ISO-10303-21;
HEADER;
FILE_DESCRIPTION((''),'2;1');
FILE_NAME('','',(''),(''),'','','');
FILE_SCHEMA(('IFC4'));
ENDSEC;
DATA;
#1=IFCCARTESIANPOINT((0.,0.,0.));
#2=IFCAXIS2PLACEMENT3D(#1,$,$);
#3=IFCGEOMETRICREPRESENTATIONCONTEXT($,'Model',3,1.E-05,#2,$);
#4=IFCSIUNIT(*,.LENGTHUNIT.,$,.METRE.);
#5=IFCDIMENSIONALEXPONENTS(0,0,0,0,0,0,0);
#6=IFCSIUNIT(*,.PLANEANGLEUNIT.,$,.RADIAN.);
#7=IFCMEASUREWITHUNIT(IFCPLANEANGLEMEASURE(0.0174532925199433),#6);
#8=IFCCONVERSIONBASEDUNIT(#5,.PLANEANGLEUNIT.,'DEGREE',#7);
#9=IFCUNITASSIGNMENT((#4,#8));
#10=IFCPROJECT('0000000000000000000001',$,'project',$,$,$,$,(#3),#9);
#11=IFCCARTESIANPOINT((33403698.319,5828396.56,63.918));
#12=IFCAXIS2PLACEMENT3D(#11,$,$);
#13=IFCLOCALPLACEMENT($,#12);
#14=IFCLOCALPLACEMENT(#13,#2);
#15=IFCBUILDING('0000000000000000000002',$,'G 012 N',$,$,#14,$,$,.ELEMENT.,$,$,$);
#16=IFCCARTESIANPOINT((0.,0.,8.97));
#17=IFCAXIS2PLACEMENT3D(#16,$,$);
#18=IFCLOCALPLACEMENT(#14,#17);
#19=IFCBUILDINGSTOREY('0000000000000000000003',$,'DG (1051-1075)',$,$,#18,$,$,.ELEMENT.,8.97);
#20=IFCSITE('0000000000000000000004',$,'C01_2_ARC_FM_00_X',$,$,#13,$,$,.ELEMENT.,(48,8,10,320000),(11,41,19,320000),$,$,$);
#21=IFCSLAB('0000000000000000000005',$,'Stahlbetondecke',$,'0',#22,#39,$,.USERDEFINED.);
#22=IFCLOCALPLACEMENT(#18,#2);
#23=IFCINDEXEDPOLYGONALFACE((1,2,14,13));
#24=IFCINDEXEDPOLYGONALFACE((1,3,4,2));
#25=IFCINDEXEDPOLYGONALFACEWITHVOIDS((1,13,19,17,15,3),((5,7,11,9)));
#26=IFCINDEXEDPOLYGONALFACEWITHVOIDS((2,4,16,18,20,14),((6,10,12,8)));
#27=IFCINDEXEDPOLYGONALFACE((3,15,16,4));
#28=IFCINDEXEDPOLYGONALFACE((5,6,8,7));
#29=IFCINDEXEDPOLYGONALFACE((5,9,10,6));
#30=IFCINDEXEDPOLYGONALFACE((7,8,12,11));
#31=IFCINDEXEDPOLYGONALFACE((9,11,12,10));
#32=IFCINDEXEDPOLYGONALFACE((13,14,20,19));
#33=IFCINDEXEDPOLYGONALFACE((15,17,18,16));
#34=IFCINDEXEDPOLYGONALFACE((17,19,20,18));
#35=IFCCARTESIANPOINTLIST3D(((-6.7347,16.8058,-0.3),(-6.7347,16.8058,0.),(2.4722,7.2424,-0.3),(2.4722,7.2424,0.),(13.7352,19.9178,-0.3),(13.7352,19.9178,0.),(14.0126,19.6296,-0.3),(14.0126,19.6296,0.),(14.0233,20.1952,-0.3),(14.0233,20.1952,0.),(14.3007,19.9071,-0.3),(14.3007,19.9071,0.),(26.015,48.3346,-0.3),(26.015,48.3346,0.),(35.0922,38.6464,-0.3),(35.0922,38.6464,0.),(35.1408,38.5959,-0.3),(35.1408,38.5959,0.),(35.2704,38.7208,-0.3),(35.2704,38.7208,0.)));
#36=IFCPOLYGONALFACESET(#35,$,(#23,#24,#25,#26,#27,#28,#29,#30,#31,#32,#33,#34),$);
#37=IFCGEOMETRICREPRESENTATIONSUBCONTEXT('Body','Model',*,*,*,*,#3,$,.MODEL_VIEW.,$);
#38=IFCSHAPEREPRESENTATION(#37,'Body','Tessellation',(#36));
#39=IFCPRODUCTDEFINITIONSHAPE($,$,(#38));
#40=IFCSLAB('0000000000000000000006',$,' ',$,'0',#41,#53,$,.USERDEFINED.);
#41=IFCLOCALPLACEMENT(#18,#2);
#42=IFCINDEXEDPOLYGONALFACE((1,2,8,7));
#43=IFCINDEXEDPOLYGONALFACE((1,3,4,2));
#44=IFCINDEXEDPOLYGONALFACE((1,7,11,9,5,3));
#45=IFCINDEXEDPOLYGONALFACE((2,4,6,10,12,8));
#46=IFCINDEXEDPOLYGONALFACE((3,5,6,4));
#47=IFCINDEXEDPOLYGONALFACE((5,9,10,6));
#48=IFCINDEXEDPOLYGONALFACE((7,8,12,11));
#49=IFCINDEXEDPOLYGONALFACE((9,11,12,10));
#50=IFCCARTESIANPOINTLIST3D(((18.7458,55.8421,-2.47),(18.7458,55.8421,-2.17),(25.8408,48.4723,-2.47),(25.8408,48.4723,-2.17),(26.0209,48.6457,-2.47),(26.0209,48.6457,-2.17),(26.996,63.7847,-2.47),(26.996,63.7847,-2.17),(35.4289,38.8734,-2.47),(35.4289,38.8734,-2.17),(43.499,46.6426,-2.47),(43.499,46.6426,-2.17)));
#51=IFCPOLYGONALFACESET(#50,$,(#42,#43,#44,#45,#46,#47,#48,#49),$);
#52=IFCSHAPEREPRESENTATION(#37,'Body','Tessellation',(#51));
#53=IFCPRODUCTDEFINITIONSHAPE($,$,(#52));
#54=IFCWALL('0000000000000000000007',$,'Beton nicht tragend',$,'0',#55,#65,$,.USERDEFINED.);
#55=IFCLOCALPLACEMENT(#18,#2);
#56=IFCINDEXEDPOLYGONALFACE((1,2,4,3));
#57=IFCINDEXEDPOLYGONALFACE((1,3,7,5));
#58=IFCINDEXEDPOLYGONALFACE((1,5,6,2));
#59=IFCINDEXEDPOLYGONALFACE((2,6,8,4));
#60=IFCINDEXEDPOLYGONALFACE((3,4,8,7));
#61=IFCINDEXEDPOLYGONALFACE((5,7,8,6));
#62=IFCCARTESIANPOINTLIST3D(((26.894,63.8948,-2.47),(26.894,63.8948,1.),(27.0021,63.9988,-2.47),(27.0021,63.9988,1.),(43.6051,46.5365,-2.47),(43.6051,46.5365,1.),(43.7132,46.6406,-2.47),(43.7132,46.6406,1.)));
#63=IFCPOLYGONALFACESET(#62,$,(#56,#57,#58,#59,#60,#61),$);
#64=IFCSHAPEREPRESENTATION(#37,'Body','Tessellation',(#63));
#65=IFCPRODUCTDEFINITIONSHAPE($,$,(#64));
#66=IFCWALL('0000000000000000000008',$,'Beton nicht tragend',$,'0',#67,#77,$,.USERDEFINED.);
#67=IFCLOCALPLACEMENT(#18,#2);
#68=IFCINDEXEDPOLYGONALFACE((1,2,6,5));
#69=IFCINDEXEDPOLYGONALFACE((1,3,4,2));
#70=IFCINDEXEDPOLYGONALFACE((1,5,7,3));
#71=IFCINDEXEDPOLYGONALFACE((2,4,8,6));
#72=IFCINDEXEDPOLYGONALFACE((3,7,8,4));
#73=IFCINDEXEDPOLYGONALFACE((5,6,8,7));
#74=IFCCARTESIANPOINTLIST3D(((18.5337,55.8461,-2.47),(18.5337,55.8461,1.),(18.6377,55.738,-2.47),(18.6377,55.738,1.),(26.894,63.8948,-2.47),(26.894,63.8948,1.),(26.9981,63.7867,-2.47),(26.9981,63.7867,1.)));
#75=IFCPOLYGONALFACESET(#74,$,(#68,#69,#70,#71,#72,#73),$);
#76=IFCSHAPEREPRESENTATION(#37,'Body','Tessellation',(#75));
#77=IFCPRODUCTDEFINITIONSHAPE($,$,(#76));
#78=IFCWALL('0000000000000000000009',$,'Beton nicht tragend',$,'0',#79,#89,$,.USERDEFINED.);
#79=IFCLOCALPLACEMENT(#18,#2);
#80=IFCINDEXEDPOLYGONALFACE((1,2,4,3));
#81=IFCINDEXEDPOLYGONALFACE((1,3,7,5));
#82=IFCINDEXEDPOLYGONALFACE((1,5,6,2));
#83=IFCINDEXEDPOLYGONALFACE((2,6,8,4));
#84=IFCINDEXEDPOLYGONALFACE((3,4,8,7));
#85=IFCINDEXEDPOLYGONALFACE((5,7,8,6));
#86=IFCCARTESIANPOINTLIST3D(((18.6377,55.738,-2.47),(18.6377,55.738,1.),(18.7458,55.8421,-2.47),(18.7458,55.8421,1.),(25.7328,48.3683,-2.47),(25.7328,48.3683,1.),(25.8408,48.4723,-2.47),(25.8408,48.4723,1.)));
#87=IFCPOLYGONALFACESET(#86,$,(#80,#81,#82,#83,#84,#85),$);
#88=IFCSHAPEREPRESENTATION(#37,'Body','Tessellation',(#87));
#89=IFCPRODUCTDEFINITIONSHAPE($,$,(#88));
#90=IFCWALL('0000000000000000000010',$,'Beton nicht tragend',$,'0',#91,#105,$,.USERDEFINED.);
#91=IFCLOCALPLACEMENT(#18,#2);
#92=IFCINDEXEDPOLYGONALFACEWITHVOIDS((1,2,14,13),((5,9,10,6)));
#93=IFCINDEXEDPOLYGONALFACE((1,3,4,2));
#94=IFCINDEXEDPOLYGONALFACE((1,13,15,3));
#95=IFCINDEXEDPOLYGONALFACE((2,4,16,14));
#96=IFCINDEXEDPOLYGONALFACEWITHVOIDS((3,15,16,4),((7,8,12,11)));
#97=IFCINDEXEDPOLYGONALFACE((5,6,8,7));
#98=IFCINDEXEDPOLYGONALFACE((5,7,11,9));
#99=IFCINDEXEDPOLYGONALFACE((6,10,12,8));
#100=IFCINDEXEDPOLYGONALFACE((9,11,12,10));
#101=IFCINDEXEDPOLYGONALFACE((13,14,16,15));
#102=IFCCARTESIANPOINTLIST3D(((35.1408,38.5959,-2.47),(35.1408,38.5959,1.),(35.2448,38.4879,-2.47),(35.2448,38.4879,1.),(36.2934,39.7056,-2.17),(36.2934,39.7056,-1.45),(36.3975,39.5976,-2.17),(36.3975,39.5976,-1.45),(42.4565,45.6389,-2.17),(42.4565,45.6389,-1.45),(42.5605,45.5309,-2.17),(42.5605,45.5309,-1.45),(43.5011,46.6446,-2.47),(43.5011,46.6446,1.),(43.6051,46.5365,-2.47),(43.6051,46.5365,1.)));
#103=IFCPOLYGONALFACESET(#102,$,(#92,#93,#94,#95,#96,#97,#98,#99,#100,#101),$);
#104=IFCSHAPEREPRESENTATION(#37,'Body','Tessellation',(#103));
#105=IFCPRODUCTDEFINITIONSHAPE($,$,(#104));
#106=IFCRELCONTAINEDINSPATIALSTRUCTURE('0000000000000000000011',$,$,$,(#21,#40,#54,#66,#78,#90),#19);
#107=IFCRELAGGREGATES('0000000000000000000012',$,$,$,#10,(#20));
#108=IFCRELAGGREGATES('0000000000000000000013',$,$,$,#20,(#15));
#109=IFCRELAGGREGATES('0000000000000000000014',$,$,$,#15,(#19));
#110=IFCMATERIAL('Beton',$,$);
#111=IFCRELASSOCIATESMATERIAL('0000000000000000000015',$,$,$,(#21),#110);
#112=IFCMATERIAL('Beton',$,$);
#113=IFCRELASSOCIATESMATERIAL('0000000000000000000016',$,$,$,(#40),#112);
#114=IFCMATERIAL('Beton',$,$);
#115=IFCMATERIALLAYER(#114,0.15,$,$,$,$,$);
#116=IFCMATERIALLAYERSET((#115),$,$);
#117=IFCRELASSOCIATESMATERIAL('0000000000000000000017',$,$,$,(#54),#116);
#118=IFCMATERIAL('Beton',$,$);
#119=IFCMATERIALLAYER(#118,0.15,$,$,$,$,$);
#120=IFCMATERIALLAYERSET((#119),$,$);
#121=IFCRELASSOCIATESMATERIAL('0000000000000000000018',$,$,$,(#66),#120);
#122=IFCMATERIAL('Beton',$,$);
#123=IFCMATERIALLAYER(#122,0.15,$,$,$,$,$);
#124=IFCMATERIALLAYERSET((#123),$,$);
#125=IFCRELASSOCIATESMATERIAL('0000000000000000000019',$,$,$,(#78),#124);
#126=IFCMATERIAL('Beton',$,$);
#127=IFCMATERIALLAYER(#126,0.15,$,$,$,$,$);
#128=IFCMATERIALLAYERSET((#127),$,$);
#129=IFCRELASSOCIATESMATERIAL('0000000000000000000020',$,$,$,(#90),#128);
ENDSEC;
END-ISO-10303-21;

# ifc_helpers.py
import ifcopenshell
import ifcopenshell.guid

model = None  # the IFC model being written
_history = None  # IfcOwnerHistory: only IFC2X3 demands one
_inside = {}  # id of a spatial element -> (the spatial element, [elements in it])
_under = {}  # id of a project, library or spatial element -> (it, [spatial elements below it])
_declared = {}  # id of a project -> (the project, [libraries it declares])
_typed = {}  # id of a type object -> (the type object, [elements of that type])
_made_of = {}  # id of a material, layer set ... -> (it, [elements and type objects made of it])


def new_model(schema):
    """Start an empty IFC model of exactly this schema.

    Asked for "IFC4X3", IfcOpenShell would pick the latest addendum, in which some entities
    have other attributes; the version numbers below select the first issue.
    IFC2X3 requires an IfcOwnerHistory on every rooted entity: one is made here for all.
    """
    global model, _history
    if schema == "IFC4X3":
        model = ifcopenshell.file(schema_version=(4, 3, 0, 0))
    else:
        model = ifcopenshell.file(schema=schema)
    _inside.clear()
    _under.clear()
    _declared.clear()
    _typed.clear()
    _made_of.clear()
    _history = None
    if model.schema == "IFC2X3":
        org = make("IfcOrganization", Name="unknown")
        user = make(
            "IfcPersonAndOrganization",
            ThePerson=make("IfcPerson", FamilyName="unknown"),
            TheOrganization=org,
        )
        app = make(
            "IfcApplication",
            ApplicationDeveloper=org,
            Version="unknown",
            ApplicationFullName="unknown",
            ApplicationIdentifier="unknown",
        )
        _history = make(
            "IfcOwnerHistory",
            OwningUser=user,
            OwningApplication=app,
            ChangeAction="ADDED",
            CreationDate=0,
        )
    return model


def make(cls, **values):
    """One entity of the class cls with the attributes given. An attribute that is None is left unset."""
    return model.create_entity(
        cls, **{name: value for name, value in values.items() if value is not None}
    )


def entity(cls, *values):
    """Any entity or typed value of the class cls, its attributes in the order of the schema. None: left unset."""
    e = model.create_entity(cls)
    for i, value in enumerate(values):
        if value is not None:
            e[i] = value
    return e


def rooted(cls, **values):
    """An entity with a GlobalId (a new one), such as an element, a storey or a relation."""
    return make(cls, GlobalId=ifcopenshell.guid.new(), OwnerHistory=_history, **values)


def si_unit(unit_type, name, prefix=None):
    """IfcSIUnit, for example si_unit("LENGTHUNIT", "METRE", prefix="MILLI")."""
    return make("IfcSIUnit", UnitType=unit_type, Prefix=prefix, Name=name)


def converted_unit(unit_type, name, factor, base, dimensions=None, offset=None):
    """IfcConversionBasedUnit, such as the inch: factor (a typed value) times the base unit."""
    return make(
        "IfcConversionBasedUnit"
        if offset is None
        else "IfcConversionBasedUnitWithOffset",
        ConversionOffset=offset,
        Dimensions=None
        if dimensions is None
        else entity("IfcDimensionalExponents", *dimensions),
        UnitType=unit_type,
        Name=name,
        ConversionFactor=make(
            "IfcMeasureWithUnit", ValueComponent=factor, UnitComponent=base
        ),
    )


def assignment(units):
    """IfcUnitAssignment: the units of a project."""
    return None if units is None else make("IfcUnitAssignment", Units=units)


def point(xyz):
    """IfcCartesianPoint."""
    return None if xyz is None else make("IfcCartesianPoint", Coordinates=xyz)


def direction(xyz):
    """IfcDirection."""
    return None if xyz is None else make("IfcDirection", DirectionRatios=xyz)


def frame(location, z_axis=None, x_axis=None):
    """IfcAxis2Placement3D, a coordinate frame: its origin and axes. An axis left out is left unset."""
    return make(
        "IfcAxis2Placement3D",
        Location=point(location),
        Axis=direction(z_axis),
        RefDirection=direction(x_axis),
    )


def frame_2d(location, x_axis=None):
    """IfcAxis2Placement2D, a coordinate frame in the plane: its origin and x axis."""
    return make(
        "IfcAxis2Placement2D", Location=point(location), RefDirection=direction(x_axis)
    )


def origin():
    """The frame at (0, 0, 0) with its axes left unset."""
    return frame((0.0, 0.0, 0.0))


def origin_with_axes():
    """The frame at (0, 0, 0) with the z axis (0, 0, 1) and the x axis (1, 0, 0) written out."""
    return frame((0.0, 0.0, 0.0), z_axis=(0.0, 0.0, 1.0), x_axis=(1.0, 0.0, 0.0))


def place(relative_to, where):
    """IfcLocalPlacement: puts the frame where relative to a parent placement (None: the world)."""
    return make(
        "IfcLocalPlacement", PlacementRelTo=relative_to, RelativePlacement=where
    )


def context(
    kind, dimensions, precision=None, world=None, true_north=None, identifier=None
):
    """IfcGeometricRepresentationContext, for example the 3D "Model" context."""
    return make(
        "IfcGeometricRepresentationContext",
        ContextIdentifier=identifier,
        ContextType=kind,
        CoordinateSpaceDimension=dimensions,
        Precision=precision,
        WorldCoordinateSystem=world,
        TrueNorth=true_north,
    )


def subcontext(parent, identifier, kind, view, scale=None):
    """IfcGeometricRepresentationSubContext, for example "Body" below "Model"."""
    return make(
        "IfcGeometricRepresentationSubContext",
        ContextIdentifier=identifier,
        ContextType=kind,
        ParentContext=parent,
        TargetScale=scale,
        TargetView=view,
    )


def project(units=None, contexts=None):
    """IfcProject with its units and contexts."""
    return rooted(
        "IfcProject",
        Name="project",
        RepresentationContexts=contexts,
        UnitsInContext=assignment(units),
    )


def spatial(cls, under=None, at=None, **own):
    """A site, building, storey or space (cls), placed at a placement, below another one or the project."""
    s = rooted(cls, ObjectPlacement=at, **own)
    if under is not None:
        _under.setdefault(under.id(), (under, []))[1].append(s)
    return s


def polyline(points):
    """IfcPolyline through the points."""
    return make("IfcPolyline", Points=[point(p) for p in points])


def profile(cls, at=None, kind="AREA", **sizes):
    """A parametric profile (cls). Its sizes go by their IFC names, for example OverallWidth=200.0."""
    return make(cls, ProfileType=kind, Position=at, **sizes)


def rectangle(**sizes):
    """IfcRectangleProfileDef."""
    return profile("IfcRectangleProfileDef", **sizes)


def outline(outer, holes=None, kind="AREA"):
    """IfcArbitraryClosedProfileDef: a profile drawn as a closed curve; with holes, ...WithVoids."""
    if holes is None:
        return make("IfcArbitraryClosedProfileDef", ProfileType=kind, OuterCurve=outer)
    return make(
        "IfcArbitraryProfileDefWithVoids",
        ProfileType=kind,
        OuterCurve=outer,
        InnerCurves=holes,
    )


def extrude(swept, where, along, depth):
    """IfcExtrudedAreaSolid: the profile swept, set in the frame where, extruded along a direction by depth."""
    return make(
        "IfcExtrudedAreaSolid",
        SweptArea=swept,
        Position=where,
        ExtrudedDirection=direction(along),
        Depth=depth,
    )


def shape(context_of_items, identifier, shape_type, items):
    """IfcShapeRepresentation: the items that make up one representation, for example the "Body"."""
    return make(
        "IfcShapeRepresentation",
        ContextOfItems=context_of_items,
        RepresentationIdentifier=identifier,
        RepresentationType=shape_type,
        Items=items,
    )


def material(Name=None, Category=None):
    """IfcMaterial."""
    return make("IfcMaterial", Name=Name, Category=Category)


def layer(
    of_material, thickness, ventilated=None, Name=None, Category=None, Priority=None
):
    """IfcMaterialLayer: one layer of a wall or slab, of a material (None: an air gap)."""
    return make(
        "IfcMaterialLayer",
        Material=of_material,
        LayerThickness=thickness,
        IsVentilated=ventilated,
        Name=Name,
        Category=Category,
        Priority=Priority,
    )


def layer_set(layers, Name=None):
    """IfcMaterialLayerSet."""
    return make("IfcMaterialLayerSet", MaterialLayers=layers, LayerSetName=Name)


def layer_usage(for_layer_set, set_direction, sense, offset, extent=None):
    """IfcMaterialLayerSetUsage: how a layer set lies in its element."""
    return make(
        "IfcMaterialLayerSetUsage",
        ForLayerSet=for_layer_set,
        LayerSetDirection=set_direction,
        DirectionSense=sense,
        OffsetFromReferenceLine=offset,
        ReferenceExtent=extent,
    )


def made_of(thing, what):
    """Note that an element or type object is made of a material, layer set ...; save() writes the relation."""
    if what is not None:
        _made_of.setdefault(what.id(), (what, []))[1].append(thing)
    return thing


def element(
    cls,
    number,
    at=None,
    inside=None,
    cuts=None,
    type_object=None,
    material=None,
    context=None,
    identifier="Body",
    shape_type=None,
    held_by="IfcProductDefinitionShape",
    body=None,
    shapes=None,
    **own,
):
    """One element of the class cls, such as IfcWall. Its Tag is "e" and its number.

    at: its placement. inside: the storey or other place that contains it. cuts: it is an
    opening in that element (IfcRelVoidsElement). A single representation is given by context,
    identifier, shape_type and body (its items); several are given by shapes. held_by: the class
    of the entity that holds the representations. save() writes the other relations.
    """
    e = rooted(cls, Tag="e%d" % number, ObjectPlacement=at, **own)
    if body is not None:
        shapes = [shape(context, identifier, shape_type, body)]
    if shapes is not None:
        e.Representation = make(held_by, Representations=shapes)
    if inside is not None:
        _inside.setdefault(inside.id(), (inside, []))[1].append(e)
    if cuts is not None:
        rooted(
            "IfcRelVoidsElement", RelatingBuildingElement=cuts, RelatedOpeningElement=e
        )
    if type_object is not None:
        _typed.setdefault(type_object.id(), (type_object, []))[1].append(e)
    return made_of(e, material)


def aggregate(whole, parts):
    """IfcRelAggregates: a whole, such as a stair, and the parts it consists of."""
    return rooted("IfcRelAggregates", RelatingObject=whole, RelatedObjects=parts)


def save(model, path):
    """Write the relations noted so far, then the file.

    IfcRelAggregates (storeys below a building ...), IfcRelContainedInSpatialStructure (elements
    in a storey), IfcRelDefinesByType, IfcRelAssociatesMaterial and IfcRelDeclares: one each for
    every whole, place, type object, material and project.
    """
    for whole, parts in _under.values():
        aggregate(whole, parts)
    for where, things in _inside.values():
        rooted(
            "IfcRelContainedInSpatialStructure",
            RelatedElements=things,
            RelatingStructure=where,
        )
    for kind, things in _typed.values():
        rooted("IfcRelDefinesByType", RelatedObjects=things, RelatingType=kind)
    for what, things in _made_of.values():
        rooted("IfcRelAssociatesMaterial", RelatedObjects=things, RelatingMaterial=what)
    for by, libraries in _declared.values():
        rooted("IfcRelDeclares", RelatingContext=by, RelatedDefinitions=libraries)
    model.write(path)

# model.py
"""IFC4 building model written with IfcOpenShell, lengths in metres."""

from ifc_helpers import new_model, entity, si_unit, converted_unit, frame, frame_2d, origin, origin_with_axes, place, context, subcontext, project, spatial, polyline, rectangle, outline, extrude, material, layer, layer_set, layer_usage, element, save


model = new_model("IFC4")

# Units and contexts
model_context = context("Model", 3, precision=1e-05, world=origin())
body_context = subcontext(model_context, "Body", "Model", "MODEL_VIEW")
ifc_project = project(units=[si_unit("LENGTHUNIT", "METRE"), converted_unit("PLANEANGLEUNIT", "DEGREE", entity("IfcPlaneAngleMeasure", 0.0174532925199433), si_unit("PLANEANGLEUNIT", "RADIAN"), dimensions=[0, 0, 0, 0, 0, 0, 0])], contexts=[model_context])

# Site, building, storey
site_placement = place(None, frame((33403698.319, 5828396.56, 63.918)))
site = spatial("IfcSite", under=ifc_project, at=site_placement, Name="C01_2_ARC_FM_00_X", CompositionType="ELEMENT", RefLatitude=(48, 8, 10, 320000), RefLongitude=(11, 41, 19, 320000))
building_placement = place(site_placement, origin())
building = spatial("IfcBuilding", under=site, at=building_placement, Name="G 012 N", CompositionType="ELEMENT")
storey_placement = place(building_placement, frame((0.0, 0.0, 8.97)))
storey = spatial("IfcBuildingStorey", under=building, at=storey_placement, Name="DG (1051-1075)", CompositionType="ELEMENT", Elevation=8.97)

# Slab, opening
ifc_material_1 = material(Name="Beton")
slab_1_placement = place(storey_placement, frame((-6.7347, 7.2424, -0.3)))
slab_1 = element("IfcSlab", 1, at=slab_1_placement, inside=storey, material=ifc_material_1, Name="Stahlbetondecke", ObjectType="0", PredefinedType="USERDEFINED", context=body_context, shape_type="SweptSolid", body=[
    extrude(outline(polyline([(41.8755, 31.3535), (42.0052, 31.4784), (32.7497, 41.0922), (0.0, 9.5634), (9.2069, 0.0), (41.827, 31.404), (41.8755, 31.3535)])), origin_with_axes(), (0.0, 0.0, 1.0), 0.3),
])
opening_1_placement = place(slab_1_placement, frame((20.4699, 12.3873, 0.0)))
element("IfcOpeningElement", 2, at=opening_1_placement, cuts=slab_1, ObjectType="Opening", context=body_context, shape_type="SweptSolid", body=[
    extrude(rectangle(XDim=0.4, YDim=0.4, at=frame_2d((0.0, 0.0), x_axis=(-0.693551, 0.720408))), frame((0.2828, 0.2828, 0.0), z_axis=(0.0, 0.0, 1.0), x_axis=(1.0, 0.0, 0.0)), (0.0, 0.0, 1.0), 0.3),
])

# Slab
ifc_material_2 = material(Name="Beton")
slab_2_placement = place(storey_placement, frame((18.7458, 38.8734, -2.47)))
element("IfcSlab", 3, at=slab_2_placement, inside=storey, material=ifc_material_2, Name=" ", ObjectType="0", PredefinedType="USERDEFINED", context=body_context, shape_type="SweptSolid", body=[
    extrude(outline(polyline([(8.2502, 24.9114), (0.0, 16.9687), (7.095, 9.5989), (7.2751, 9.7723), (16.6831, 0.0), (24.7532, 7.7692), (8.2502, 24.9114)])), origin_with_axes(), (0.0, 0.0, 1.0), 0.3),
])

# Walls
ifc_material_3 = material(Name="Beton")
ifc_layer_1 = layer(ifc_material_3, 0.15)
ifc_layer_set_1 = layer_set([ifc_layer_1])
ifc_layer_usage_1 = layer_usage(ifc_layer_set_1, "AXIS2", "POSITIVE", 0.0)
wall_1_placement = place(storey_placement, frame((43.7132, 46.6406, -2.47), z_axis=(0.0, 0.0, 1.0), x_axis=(-0.693551, 0.720408, 0.0)))
element("IfcWall", 4, at=wall_1_placement, inside=storey, material=ifc_layer_usage_1, Name="Beton nicht tragend", ObjectType="0", PredefinedType="USERDEFINED", context=body_context, shape_type="SweptSolid", body=[
    extrude(rectangle(XDim=24.095, YDim=0.15, at=frame_2d((12.0475, 0.075), x_axis=(1.0, 0.0))), origin_with_axes(), (0.0, 0.0, 1.0), 3.47),
])
ifc_material_4 = material(Name="Beton")
ifc_layer_2 = layer(ifc_material_4, 0.15)
ifc_layer_set_2 = layer_set([ifc_layer_2])
ifc_layer_usage_2 = layer_usage(ifc_layer_set_2, "AXIS2", "POSITIVE", 0.0)
wall_2_placement = place(storey_placement, frame((26.894, 63.8948, -2.47), z_axis=(0.0, 0.0, 1.0), x_axis=(-0.720408, -0.693551, 0.0)))
element("IfcWall", 5, at=wall_2_placement, inside=storey, material=ifc_layer_usage_2, Name="Beton nicht tragend", ObjectType="0", PredefinedType="USERDEFINED", context=body_context, shape_type="SweptSolid", body=[
    extrude(rectangle(XDim=11.605, YDim=0.15, at=frame_2d((5.8025, 0.075), x_axis=(1.0, 0.0))), origin_with_axes(), (0.0, 0.0, 1.0), 3.47),
])
ifc_material_5 = material(Name="Beton")
ifc_layer_3 = layer(ifc_material_5, 0.15)
ifc_layer_set_3 = layer_set([ifc_layer_3])
ifc_layer_usage_3 = layer_usage(ifc_layer_set_3, "AXIS2", "POSITIVE", 0.0)
wall_3_placement = place(storey_placement, frame((18.6377, 55.738, -2.47), z_axis=(0.0, 0.0, 1.0), x_axis=(0.693551, -0.720408, 0.0)))
element("IfcWall", 6, at=wall_3_placement, inside=storey, material=ifc_layer_usage_3, Name="Beton nicht tragend", ObjectType="0", PredefinedType="USERDEFINED", context=body_context, shape_type="SweptSolid", body=[
    extrude(rectangle(XDim=10.23, YDim=0.15, at=frame_2d((5.115, 0.075), x_axis=(1.0, 0.0))), origin_with_axes(), (0.0, 0.0, 1.0), 3.47),
])

# Wall, opening
ifc_material_6 = material(Name="Beton")
ifc_layer_4 = layer(ifc_material_6, 0.15)
ifc_layer_set_4 = layer_set([ifc_layer_4])
ifc_layer_usage_4 = layer_usage(ifc_layer_set_4, "AXIS2", "POSITIVE", 0.0)
wall_4_placement = place(storey_placement, frame((35.2448, 38.4879, -2.47), z_axis=(0.0, 0.0, 1.0), x_axis=(0.720408, 0.693551, 0.0)))
wall_4 = element("IfcWall", 7, at=wall_4_placement, inside=storey, material=ifc_layer_usage_4, Name="Beton nicht tragend", ObjectType="0", PredefinedType="USERDEFINED", context=body_context, shape_type="SweptSolid", body=[
    extrude(rectangle(XDim=11.605, YDim=0.15, at=frame_2d((5.8025, 0.075), x_axis=(1.0, 0.0))), origin_with_axes(), (0.0, 0.0, 1.0), 3.47),
])
opening_2_placement = place(wall_4_placement, frame((10.155, 0.15, 0.3), z_axis=(0.0, -1.0, 0.0), x_axis=(0.0, 0.0, 1.0)))
element("IfcOpeningElement", 8, at=opening_2_placement, cuts=wall_4, ObjectType="Opening", context=body_context, shape_type="SweptSolid", body=[
    extrude(outline(polyline([(0.0, 8.555), (0.72, 8.555), (0.72, 0.0), (0.0, 0.0), (0.0, 8.555)])), origin_with_axes(), (0.0, 0.0, 1.0), 0.15),
])

save(model, "model.ifc")
